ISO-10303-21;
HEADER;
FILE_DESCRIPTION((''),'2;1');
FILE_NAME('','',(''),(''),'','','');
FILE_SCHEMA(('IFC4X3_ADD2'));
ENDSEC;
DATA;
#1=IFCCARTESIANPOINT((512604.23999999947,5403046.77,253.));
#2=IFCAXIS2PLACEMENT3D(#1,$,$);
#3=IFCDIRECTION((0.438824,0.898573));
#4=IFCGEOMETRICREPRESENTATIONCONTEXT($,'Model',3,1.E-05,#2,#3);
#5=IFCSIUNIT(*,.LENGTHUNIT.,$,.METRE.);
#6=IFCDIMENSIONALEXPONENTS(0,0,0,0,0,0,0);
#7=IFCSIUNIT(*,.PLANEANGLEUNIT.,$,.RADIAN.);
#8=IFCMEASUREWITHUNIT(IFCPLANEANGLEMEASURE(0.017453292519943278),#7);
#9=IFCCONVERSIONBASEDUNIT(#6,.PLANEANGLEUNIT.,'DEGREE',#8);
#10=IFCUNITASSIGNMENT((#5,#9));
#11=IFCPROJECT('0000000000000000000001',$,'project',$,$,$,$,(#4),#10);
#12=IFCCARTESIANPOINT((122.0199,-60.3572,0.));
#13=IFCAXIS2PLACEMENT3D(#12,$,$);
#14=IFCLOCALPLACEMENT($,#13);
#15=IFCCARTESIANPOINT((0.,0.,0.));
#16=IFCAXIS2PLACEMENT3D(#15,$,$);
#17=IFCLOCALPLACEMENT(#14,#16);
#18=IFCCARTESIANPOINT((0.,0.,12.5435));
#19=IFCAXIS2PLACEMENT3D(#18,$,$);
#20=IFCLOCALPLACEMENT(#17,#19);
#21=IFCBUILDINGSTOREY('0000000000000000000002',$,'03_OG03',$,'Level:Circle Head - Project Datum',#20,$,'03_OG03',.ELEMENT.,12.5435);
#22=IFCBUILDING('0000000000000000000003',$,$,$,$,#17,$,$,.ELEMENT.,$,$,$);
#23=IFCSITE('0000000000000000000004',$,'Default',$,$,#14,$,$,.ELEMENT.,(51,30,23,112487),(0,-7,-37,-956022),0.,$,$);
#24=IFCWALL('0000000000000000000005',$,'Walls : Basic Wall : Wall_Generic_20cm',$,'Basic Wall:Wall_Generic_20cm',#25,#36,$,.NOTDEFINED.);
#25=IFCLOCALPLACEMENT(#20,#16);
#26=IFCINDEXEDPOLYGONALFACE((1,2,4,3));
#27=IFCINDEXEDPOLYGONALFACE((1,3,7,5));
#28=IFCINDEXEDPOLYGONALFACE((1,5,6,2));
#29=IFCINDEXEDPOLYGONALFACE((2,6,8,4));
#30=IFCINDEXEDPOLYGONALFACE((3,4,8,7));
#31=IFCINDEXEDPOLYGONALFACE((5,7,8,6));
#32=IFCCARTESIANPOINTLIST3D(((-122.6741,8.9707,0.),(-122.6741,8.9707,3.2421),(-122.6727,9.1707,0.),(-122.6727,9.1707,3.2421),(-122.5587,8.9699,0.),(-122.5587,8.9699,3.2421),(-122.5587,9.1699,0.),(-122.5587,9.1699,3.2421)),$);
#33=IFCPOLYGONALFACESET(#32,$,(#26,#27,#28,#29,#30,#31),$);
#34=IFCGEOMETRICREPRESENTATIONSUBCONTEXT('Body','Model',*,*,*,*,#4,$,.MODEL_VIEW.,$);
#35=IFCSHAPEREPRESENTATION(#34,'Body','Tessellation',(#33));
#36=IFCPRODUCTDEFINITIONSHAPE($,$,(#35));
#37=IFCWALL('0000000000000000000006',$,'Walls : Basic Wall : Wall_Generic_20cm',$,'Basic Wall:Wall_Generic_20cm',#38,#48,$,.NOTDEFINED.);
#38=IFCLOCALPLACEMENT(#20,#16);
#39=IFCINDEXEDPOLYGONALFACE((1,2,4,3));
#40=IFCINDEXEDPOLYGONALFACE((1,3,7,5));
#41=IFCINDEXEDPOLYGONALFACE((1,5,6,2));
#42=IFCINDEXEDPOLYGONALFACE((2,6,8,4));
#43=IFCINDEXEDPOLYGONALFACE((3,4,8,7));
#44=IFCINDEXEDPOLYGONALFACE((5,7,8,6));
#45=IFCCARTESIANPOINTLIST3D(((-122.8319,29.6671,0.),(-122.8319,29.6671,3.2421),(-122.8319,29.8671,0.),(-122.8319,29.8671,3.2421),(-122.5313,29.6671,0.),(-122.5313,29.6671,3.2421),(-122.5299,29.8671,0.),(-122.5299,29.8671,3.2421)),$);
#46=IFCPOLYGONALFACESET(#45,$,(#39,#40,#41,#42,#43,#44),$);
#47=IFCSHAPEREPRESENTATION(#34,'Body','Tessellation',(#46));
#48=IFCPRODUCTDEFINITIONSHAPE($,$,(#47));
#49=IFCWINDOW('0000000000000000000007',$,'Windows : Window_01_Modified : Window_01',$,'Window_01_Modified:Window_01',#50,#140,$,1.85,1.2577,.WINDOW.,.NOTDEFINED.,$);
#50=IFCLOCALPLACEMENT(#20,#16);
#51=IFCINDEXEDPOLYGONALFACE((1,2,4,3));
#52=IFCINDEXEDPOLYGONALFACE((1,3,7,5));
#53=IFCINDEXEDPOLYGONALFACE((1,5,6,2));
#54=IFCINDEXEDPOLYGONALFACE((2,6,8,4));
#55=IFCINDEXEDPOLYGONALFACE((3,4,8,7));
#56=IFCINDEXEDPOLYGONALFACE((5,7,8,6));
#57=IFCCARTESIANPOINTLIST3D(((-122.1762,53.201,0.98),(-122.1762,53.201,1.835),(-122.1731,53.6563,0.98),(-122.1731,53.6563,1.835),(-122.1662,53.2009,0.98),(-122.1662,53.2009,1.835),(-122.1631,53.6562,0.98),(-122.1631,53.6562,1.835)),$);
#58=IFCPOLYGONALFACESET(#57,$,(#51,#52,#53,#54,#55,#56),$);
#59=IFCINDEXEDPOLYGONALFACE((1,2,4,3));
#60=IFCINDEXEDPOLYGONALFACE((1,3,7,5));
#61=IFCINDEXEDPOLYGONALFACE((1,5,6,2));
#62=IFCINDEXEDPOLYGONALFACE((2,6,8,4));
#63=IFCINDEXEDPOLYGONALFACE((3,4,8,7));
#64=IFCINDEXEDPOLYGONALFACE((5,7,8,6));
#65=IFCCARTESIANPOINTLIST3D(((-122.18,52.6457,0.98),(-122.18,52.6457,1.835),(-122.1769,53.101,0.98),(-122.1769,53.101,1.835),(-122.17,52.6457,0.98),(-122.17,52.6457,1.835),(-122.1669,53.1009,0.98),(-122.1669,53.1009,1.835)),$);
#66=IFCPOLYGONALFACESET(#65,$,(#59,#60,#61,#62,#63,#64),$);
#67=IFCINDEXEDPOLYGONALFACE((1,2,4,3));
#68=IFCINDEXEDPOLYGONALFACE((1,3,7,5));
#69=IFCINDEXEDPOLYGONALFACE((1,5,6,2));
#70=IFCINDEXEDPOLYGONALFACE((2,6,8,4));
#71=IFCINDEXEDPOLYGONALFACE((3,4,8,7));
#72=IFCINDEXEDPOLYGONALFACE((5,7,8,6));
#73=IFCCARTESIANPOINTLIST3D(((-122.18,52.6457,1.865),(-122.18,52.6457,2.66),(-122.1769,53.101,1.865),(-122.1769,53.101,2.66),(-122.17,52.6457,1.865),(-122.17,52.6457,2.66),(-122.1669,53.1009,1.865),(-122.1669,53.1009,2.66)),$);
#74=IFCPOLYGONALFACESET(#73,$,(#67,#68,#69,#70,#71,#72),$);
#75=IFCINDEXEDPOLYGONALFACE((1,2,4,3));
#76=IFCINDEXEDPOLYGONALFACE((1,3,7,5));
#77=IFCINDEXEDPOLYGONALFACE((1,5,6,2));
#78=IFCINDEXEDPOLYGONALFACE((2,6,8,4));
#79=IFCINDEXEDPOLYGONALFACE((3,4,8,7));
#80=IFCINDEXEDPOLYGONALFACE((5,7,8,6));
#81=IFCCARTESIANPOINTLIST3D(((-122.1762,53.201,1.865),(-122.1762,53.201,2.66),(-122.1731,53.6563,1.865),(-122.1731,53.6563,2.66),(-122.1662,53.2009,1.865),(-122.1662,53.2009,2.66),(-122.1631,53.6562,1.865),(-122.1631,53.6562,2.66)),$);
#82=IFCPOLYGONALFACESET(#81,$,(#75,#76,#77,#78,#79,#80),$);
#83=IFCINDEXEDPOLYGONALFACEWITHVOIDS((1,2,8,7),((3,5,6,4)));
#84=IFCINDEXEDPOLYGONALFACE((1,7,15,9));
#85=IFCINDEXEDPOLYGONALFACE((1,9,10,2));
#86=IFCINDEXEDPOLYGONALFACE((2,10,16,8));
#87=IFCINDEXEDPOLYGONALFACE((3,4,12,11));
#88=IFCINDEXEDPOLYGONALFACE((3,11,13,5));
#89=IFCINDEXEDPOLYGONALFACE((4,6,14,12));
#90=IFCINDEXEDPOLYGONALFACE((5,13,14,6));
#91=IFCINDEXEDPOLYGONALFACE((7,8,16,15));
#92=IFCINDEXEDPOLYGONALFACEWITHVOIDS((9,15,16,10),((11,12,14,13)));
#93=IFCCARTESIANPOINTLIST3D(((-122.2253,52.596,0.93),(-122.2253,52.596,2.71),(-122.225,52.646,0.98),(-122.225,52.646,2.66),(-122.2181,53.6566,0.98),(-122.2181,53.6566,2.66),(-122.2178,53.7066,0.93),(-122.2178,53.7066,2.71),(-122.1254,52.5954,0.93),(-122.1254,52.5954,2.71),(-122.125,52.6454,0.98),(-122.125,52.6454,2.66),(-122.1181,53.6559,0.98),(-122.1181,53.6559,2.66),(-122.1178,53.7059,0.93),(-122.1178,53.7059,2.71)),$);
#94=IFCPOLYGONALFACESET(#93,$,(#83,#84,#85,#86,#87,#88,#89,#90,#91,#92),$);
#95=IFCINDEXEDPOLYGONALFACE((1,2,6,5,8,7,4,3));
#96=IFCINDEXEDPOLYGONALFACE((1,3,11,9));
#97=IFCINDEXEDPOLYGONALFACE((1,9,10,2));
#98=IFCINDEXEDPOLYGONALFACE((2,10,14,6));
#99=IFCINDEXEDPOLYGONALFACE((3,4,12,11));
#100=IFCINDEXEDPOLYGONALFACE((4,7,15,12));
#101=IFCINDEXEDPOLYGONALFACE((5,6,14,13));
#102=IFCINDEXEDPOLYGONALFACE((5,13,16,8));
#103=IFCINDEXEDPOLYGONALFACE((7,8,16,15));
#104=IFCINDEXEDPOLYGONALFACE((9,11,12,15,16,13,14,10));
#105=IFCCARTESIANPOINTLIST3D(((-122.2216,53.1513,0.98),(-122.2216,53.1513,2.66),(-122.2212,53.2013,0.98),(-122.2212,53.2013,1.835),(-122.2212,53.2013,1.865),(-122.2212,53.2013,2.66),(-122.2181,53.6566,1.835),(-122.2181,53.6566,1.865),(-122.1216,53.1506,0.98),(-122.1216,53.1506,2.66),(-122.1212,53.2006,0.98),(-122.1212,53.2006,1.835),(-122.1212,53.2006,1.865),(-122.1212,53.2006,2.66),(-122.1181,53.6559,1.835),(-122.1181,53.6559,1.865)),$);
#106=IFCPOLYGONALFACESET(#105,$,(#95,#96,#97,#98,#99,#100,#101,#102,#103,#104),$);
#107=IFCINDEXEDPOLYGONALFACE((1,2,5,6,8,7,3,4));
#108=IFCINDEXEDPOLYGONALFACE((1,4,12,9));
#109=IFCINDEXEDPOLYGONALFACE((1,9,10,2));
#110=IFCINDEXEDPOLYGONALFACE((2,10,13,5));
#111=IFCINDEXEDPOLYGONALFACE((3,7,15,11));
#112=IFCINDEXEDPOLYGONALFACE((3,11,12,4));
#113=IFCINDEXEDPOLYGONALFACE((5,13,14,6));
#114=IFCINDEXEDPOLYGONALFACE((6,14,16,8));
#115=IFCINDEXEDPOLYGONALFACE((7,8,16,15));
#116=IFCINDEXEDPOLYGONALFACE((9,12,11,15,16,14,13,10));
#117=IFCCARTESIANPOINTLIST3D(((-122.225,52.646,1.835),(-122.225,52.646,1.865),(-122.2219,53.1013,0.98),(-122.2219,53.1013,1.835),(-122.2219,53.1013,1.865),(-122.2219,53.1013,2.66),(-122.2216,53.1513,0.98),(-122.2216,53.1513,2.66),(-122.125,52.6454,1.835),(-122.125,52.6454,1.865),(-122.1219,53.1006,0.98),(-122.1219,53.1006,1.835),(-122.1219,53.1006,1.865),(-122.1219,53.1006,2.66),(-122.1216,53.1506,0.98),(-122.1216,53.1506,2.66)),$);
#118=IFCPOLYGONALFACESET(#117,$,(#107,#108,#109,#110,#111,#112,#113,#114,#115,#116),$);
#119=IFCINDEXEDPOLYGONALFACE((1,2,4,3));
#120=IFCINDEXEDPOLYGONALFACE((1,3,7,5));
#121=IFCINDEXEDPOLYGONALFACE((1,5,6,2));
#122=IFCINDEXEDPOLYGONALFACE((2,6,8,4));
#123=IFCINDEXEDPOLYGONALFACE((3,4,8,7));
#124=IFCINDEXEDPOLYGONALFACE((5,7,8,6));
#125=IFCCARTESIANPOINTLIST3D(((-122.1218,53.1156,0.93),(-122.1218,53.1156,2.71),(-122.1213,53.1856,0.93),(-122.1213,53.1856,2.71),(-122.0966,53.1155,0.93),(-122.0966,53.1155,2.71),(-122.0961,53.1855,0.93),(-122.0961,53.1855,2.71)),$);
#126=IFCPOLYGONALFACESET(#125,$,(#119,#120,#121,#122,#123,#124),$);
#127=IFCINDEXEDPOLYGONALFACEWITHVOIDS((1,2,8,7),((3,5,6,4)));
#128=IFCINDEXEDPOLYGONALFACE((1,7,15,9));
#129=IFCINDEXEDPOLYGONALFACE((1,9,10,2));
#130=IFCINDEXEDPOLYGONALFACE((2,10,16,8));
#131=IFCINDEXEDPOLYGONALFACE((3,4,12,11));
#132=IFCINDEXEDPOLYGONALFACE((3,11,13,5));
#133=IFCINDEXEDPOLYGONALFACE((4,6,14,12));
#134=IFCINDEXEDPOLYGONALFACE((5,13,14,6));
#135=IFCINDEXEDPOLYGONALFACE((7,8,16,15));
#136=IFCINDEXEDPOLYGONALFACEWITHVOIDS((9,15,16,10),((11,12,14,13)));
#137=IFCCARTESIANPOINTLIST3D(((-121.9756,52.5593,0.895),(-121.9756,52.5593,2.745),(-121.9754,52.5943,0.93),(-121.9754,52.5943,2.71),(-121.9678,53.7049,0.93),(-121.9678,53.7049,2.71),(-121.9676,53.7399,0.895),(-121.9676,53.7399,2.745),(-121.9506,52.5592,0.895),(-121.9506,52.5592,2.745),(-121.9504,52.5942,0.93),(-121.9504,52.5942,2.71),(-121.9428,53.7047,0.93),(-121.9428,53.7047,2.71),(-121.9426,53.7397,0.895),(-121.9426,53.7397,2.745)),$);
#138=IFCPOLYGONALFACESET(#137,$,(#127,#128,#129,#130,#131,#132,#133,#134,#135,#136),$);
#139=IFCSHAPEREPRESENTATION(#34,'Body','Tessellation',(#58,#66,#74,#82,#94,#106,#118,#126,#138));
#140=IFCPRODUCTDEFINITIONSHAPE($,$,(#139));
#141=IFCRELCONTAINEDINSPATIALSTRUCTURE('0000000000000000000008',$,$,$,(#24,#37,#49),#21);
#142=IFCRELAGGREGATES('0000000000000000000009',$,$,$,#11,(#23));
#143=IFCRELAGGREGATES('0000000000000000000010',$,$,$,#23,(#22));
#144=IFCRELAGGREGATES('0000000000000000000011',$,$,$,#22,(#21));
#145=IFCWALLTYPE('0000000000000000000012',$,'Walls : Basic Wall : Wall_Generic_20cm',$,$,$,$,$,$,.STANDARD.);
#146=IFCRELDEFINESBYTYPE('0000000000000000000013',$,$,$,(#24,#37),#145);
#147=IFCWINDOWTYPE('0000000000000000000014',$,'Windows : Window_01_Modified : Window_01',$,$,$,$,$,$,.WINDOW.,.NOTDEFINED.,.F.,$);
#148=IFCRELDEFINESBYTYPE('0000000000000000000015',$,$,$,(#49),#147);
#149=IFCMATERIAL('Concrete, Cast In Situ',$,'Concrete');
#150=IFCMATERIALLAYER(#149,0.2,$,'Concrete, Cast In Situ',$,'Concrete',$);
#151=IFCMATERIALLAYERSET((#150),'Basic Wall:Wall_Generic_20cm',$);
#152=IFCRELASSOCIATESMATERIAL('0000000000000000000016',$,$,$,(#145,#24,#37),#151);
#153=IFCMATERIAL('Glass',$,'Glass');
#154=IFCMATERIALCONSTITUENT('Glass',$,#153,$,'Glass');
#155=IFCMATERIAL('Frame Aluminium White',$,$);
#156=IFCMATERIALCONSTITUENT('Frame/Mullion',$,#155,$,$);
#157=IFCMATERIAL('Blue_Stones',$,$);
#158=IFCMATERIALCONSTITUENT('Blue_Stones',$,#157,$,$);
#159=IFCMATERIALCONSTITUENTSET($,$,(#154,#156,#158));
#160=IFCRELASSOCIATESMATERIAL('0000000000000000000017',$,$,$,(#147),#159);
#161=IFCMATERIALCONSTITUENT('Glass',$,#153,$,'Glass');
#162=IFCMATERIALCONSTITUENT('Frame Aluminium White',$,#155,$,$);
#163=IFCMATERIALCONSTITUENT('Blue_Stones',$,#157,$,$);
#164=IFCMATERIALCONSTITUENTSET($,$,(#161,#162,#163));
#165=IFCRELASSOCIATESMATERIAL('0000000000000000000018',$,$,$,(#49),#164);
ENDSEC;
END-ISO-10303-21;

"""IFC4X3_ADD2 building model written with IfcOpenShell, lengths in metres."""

from ifc_helpers import new_model, entity, si_unit, converted_unit, direction, frame, frame_2d, origin, place, context, subcontext, project, spatial, polyline, rectangle, outline, extrude, clip, bounded_halfspace, source, transform, mapped, material, layer, layer_set, constituent, constituent_set, type_object, type_shapes, element, save


model = new_model("IFC4X3_ADD2")

# Units and contexts
model_context = context("Model", 3, precision=1e-05, world=frame((512604.23999999947, 5403046.77, 253.0)), true_north=direction((0.438824, 0.898573)))
body_context = subcontext(model_context, "Body", "Model", "MODEL_VIEW")
ifc_project = project(units=[si_unit("LENGTHUNIT", "METRE"), converted_unit("PLANEANGLEUNIT", "DEGREE", entity("IfcPlaneAngleMeasure", 0.017453292519943278), si_unit("PLANEANGLEUNIT", "RADIAN"), dimensions=[0, 0, 0, 0, 0, 0, 0])], contexts=[model_context])

# Site, building, storey
site_placement = place(None, frame((122.0199, -60.3572, 0.0)))
site = spatial("IfcSite", under=ifc_project, at=site_placement, Name="Default", CompositionType="ELEMENT", RefLatitude=(51, 30, 23, 112487), RefLongitude=(0, -7, -37, -956022), RefElevation=0.0)
building_placement = place(site_placement, origin())
building = spatial("IfcBuilding", under=site, at=building_placement, CompositionType="ELEMENT")
storey_placement = place(building_placement, frame((0.0, 0.0, 12.5435)))
storey = spatial("IfcBuildingStorey", under=building, at=storey_placement, Name="03_OG03", ObjectType="Level:Circle Head - Project Datum", LongName="03_OG03", CompositionType="ELEMENT", Elevation=12.5435)

# Walls
ifc_material_1 = material(Name="Concrete, Cast In Situ", Category="Concrete")
ifc_layer_1 = layer(ifc_material_1, 0.2, Name="Concrete, Cast In Situ", Category="Concrete")
ifc_layer_set_1 = layer_set([ifc_layer_1], Name="Basic Wall:Wall_Generic_20cm")
wall_type_1 = type_object("IfcWallType", Name="Walls : Basic Wall : Wall_Generic_20cm", PredefinedType="STANDARD", material=ifc_layer_set_1)
wall_1_placement = place(storey_placement, frame((-122.558, 9.0699, 0.0), z_axis=(0.0, 0.0, 1.0), x_axis=(-0.999977, 0.006814, 0.0)))
element("IfcWall", 1, at=wall_1_placement, inside=storey, type_object=wall_type_1, material=ifc_layer_set_1, Name="Walls : Basic Wall : Wall_Generic_20cm", ObjectType="Basic Wall:Wall_Generic_20cm", PredefinedType="NOTDEFINED", context=body_context, shape_type="Clipping", body=[
    clip(extrude(outline(polyline([(0.1154, -0.1), (0.1154, 0.1), (0.0, 0.1), (0.0014, -0.1), (0.1154, -0.1)])), origin(), (0.0, 0.0, 1.0), 3.2421), bounded_halfspace(frame((0.0014, -0.1, 3.2421), z_axis=(0.0, 0.0, -1.0), x_axis=(-0.003977, 0.999992, 0.0)), True, frame((0.0014, -0.1, 3.2421)), polyline([(0.0, 0.0), (0.114, 0.0), (0.114, 0.2), (-0.0014, 0.2), (0.0, 0.0)]))),
])
wall_2_placement = place(storey_placement, frame((-122.8319, 29.7671, 0.0)))
element("IfcWall", 2, at=wall_2_placement, inside=storey, type_object=wall_type_1, material=ifc_layer_set_1, Name="Walls : Basic Wall : Wall_Generic_20cm", ObjectType="Basic Wall:Wall_Generic_20cm", PredefinedType="NOTDEFINED", context=body_context, shape_type="Clipping", body=[
    clip(extrude(outline(polyline([(0.3007, -0.1), (0.302, 0.1), (0.0492, 0.1), (0.0, 0.1), (0.0, -0.0596), (0.0, -0.1), (0.3007, -0.1)])), origin(), (0.0, 0.0, 1.0), 3.2421), bounded_halfspace(frame((0.0, -0.1, 3.2421), z_axis=(0.0, 0.0, -1.0), x_axis=(-0.002837, -0.999996, 0.0)), True, frame((0.0, -0.1, 3.2421)), polyline([(0.0, 0.0), (0.3007, 0.0), (0.302, 0.2), (0.0, 0.2), (0.0, 0.0404), (0.0, 0.0)]))),
])

# Window
ifc_material_2 = material(Name="Glass", Category="Glass")
ifc_constituent_1 = constituent(ifc_material_2, Name="Glass", Category="Glass")
ifc_material_3 = material(Name="Frame Aluminium White")
ifc_constituent_2 = constituent(ifc_material_3, Name="Frame Aluminium White")
ifc_material_4 = material(Name="Blue_Stones")
ifc_constituent_3 = constituent(ifc_material_4, Name="Blue_Stones")
ifc_constituent_set_1 = constituent_set(constituents=[ifc_constituent_1, ifc_constituent_2, ifc_constituent_3])
ifc_constituent_4 = constituent(ifc_material_2, Name="Glass", Category="Glass")
ifc_constituent_5 = constituent(ifc_material_3, Name="Frame/Mullion")
ifc_constituent_6 = constituent(ifc_material_4, Name="Blue_Stones")
ifc_constituent_set_2 = constituent_set(constituents=[ifc_constituent_4, ifc_constituent_5, ifc_constituent_6])
window_type_1 = type_object("IfcWindowType", Name="Windows : Window_01_Modified : Window_01", ParameterTakesPrecedence=False, PartitioningType="NOTDEFINED", PredefinedType="WINDOW", material=ifc_constituent_set_2)
shared_shape_1 = source(origin(), body_context, "Body", "SweptSolid", [
    extrude(rectangle(XDim=0.4553, YDim=0.01, at=frame_2d((0.0, 0.0), x_axis=(1.0, 0.0))), frame((0.3108, -0.2, 0.0514), z_axis=(0.0, 0.0, 1.0), x_axis=(-1.0, 0.0, 0.0)), (0.0, 0.0, 1.0), 0.855),
    extrude(rectangle(XDim=0.01, YDim=0.4553, at=frame_2d((0.0, 0.0), x_axis=(1.0, 0.0))), frame((0.8661, -0.2, 0.0514), z_axis=(0.0, 0.0, 1.0), x_axis=(0.0, 1.0, 0.0)), (0.0, 0.0, 1.0), 0.855),
    extrude(rectangle(XDim=0.4553, YDim=0.01, at=frame_2d((0.0, 0.0), x_axis=(1.0, 0.0))), frame((0.8661, -0.2, 0.9364), z_axis=(0.0, 0.0, 1.0), x_axis=(-1.0, 0.0, 0.0)), (0.0, 0.0, 1.0), 0.795),
    extrude(rectangle(XDim=0.4553, YDim=0.01, at=frame_2d((0.0, 0.0), x_axis=(1.0, 0.0))), frame((0.3108, -0.2, 0.9364), z_axis=(0.0, 0.0, 1.0), x_axis=(-1.0, 0.0, 0.0)), (0.0, 0.0, 1.0), 0.795),
    extrude(outline(polyline([(-0.89, -0.5553), (0.89, -0.5553), (0.89, 0.5553), (-0.89, 0.5553), (-0.89, -0.5553)]), holes=[polyline([(0.84, 0.5053), (0.84, -0.5053), (-0.84, -0.5053), (-0.84, 0.5053), (0.84, 0.5053)])]), frame((0.5885, -0.25, 0.8914), z_axis=(0.0, 1.0, 0.0), x_axis=(0.0, 0.0, 1.0)), (0.0, 0.0, 1.0), 0.1),
    extrude(outline(polyline([(0.03, 0.1013), (0.825, 0.1013), (0.825, 0.1513), (-0.855, 0.1513), (-0.855, 0.1013), (0.0, 0.1013), (0.0, -0.354), (0.03, -0.354), (0.03, 0.1013)])), frame((0.4372, -0.25, 0.9064), z_axis=(0.0, 1.0, 0.0), x_axis=(0.0, 0.0, 1.0)), (0.0, 0.0, 1.0), 0.1),
    extrude(outline(polyline([(-0.825, -0.1013), (-0.825, -0.1513), (0.855, -0.1513), (0.855, -0.1013), (0.0, -0.1013), (0.0, 0.354), (-0.03, 0.354), (-0.03, -0.1013), (-0.825, -0.1013)])), frame((0.7398, -0.25, 0.9064), z_axis=(0.0, -1.0, 0.0), x_axis=(0.0, 0.0, -1.0)), (0.0, 0.0, -1.0), 0.1),
    extrude(rectangle(XDim=0.0253, YDim=0.07, at=frame_2d((0.0, 0.0), x_axis=(1.0, 0.0))), frame((0.5885, -0.1374, 0.0014), z_axis=(0.0, 0.0, 1.0), x_axis=(0.0, -1.0, 0.0)), (0.0, 0.0, 1.0), 1.78),
    extrude(outline(polyline([(-0.5903, -0.925), (0.5903, -0.925), (0.5903, 0.925), (-0.5903, 0.925), (-0.5903, -0.925)]), holes=[polyline([(-0.5553, -0.89), (-0.5553, 0.89), (0.5553, 0.89), (0.5553, -0.89), (-0.5553, -0.89)])]), frame((0.5885, 0.0, 0.8914), z_axis=(0.0, 1.0, 0.0), x_axis=(1.0, 0.0, 0.0)), (0.0, 0.0, 1.0), 0.025),
])
type_shapes(window_type_1, [shared_shape_1])
window_1_placement = place(storey_placement, frame((-121.9676, 53.7381, 0.9286), z_axis=(0.0, 0.0, 1.0), x_axis=(-0.0068, -0.999977, 0.0)))
element("IfcWindow", 3, at=window_1_placement, inside=storey, type_object=window_type_1, material=ifc_constituent_set_1, Name="Windows : Window_01_Modified : Window_01", ObjectType="Window_01_Modified:Window_01", OverallHeight=1.85, OverallWidth=1.2577, PartitioningType="NOTDEFINED", PredefinedType="WINDOW", context=body_context, shape_type="MappedRepresentation", body=[
    mapped(shared_shape_1, transform((0.0, 0.0, 0.0), scale=1.0)),
])

save(model, "model.ifc")
